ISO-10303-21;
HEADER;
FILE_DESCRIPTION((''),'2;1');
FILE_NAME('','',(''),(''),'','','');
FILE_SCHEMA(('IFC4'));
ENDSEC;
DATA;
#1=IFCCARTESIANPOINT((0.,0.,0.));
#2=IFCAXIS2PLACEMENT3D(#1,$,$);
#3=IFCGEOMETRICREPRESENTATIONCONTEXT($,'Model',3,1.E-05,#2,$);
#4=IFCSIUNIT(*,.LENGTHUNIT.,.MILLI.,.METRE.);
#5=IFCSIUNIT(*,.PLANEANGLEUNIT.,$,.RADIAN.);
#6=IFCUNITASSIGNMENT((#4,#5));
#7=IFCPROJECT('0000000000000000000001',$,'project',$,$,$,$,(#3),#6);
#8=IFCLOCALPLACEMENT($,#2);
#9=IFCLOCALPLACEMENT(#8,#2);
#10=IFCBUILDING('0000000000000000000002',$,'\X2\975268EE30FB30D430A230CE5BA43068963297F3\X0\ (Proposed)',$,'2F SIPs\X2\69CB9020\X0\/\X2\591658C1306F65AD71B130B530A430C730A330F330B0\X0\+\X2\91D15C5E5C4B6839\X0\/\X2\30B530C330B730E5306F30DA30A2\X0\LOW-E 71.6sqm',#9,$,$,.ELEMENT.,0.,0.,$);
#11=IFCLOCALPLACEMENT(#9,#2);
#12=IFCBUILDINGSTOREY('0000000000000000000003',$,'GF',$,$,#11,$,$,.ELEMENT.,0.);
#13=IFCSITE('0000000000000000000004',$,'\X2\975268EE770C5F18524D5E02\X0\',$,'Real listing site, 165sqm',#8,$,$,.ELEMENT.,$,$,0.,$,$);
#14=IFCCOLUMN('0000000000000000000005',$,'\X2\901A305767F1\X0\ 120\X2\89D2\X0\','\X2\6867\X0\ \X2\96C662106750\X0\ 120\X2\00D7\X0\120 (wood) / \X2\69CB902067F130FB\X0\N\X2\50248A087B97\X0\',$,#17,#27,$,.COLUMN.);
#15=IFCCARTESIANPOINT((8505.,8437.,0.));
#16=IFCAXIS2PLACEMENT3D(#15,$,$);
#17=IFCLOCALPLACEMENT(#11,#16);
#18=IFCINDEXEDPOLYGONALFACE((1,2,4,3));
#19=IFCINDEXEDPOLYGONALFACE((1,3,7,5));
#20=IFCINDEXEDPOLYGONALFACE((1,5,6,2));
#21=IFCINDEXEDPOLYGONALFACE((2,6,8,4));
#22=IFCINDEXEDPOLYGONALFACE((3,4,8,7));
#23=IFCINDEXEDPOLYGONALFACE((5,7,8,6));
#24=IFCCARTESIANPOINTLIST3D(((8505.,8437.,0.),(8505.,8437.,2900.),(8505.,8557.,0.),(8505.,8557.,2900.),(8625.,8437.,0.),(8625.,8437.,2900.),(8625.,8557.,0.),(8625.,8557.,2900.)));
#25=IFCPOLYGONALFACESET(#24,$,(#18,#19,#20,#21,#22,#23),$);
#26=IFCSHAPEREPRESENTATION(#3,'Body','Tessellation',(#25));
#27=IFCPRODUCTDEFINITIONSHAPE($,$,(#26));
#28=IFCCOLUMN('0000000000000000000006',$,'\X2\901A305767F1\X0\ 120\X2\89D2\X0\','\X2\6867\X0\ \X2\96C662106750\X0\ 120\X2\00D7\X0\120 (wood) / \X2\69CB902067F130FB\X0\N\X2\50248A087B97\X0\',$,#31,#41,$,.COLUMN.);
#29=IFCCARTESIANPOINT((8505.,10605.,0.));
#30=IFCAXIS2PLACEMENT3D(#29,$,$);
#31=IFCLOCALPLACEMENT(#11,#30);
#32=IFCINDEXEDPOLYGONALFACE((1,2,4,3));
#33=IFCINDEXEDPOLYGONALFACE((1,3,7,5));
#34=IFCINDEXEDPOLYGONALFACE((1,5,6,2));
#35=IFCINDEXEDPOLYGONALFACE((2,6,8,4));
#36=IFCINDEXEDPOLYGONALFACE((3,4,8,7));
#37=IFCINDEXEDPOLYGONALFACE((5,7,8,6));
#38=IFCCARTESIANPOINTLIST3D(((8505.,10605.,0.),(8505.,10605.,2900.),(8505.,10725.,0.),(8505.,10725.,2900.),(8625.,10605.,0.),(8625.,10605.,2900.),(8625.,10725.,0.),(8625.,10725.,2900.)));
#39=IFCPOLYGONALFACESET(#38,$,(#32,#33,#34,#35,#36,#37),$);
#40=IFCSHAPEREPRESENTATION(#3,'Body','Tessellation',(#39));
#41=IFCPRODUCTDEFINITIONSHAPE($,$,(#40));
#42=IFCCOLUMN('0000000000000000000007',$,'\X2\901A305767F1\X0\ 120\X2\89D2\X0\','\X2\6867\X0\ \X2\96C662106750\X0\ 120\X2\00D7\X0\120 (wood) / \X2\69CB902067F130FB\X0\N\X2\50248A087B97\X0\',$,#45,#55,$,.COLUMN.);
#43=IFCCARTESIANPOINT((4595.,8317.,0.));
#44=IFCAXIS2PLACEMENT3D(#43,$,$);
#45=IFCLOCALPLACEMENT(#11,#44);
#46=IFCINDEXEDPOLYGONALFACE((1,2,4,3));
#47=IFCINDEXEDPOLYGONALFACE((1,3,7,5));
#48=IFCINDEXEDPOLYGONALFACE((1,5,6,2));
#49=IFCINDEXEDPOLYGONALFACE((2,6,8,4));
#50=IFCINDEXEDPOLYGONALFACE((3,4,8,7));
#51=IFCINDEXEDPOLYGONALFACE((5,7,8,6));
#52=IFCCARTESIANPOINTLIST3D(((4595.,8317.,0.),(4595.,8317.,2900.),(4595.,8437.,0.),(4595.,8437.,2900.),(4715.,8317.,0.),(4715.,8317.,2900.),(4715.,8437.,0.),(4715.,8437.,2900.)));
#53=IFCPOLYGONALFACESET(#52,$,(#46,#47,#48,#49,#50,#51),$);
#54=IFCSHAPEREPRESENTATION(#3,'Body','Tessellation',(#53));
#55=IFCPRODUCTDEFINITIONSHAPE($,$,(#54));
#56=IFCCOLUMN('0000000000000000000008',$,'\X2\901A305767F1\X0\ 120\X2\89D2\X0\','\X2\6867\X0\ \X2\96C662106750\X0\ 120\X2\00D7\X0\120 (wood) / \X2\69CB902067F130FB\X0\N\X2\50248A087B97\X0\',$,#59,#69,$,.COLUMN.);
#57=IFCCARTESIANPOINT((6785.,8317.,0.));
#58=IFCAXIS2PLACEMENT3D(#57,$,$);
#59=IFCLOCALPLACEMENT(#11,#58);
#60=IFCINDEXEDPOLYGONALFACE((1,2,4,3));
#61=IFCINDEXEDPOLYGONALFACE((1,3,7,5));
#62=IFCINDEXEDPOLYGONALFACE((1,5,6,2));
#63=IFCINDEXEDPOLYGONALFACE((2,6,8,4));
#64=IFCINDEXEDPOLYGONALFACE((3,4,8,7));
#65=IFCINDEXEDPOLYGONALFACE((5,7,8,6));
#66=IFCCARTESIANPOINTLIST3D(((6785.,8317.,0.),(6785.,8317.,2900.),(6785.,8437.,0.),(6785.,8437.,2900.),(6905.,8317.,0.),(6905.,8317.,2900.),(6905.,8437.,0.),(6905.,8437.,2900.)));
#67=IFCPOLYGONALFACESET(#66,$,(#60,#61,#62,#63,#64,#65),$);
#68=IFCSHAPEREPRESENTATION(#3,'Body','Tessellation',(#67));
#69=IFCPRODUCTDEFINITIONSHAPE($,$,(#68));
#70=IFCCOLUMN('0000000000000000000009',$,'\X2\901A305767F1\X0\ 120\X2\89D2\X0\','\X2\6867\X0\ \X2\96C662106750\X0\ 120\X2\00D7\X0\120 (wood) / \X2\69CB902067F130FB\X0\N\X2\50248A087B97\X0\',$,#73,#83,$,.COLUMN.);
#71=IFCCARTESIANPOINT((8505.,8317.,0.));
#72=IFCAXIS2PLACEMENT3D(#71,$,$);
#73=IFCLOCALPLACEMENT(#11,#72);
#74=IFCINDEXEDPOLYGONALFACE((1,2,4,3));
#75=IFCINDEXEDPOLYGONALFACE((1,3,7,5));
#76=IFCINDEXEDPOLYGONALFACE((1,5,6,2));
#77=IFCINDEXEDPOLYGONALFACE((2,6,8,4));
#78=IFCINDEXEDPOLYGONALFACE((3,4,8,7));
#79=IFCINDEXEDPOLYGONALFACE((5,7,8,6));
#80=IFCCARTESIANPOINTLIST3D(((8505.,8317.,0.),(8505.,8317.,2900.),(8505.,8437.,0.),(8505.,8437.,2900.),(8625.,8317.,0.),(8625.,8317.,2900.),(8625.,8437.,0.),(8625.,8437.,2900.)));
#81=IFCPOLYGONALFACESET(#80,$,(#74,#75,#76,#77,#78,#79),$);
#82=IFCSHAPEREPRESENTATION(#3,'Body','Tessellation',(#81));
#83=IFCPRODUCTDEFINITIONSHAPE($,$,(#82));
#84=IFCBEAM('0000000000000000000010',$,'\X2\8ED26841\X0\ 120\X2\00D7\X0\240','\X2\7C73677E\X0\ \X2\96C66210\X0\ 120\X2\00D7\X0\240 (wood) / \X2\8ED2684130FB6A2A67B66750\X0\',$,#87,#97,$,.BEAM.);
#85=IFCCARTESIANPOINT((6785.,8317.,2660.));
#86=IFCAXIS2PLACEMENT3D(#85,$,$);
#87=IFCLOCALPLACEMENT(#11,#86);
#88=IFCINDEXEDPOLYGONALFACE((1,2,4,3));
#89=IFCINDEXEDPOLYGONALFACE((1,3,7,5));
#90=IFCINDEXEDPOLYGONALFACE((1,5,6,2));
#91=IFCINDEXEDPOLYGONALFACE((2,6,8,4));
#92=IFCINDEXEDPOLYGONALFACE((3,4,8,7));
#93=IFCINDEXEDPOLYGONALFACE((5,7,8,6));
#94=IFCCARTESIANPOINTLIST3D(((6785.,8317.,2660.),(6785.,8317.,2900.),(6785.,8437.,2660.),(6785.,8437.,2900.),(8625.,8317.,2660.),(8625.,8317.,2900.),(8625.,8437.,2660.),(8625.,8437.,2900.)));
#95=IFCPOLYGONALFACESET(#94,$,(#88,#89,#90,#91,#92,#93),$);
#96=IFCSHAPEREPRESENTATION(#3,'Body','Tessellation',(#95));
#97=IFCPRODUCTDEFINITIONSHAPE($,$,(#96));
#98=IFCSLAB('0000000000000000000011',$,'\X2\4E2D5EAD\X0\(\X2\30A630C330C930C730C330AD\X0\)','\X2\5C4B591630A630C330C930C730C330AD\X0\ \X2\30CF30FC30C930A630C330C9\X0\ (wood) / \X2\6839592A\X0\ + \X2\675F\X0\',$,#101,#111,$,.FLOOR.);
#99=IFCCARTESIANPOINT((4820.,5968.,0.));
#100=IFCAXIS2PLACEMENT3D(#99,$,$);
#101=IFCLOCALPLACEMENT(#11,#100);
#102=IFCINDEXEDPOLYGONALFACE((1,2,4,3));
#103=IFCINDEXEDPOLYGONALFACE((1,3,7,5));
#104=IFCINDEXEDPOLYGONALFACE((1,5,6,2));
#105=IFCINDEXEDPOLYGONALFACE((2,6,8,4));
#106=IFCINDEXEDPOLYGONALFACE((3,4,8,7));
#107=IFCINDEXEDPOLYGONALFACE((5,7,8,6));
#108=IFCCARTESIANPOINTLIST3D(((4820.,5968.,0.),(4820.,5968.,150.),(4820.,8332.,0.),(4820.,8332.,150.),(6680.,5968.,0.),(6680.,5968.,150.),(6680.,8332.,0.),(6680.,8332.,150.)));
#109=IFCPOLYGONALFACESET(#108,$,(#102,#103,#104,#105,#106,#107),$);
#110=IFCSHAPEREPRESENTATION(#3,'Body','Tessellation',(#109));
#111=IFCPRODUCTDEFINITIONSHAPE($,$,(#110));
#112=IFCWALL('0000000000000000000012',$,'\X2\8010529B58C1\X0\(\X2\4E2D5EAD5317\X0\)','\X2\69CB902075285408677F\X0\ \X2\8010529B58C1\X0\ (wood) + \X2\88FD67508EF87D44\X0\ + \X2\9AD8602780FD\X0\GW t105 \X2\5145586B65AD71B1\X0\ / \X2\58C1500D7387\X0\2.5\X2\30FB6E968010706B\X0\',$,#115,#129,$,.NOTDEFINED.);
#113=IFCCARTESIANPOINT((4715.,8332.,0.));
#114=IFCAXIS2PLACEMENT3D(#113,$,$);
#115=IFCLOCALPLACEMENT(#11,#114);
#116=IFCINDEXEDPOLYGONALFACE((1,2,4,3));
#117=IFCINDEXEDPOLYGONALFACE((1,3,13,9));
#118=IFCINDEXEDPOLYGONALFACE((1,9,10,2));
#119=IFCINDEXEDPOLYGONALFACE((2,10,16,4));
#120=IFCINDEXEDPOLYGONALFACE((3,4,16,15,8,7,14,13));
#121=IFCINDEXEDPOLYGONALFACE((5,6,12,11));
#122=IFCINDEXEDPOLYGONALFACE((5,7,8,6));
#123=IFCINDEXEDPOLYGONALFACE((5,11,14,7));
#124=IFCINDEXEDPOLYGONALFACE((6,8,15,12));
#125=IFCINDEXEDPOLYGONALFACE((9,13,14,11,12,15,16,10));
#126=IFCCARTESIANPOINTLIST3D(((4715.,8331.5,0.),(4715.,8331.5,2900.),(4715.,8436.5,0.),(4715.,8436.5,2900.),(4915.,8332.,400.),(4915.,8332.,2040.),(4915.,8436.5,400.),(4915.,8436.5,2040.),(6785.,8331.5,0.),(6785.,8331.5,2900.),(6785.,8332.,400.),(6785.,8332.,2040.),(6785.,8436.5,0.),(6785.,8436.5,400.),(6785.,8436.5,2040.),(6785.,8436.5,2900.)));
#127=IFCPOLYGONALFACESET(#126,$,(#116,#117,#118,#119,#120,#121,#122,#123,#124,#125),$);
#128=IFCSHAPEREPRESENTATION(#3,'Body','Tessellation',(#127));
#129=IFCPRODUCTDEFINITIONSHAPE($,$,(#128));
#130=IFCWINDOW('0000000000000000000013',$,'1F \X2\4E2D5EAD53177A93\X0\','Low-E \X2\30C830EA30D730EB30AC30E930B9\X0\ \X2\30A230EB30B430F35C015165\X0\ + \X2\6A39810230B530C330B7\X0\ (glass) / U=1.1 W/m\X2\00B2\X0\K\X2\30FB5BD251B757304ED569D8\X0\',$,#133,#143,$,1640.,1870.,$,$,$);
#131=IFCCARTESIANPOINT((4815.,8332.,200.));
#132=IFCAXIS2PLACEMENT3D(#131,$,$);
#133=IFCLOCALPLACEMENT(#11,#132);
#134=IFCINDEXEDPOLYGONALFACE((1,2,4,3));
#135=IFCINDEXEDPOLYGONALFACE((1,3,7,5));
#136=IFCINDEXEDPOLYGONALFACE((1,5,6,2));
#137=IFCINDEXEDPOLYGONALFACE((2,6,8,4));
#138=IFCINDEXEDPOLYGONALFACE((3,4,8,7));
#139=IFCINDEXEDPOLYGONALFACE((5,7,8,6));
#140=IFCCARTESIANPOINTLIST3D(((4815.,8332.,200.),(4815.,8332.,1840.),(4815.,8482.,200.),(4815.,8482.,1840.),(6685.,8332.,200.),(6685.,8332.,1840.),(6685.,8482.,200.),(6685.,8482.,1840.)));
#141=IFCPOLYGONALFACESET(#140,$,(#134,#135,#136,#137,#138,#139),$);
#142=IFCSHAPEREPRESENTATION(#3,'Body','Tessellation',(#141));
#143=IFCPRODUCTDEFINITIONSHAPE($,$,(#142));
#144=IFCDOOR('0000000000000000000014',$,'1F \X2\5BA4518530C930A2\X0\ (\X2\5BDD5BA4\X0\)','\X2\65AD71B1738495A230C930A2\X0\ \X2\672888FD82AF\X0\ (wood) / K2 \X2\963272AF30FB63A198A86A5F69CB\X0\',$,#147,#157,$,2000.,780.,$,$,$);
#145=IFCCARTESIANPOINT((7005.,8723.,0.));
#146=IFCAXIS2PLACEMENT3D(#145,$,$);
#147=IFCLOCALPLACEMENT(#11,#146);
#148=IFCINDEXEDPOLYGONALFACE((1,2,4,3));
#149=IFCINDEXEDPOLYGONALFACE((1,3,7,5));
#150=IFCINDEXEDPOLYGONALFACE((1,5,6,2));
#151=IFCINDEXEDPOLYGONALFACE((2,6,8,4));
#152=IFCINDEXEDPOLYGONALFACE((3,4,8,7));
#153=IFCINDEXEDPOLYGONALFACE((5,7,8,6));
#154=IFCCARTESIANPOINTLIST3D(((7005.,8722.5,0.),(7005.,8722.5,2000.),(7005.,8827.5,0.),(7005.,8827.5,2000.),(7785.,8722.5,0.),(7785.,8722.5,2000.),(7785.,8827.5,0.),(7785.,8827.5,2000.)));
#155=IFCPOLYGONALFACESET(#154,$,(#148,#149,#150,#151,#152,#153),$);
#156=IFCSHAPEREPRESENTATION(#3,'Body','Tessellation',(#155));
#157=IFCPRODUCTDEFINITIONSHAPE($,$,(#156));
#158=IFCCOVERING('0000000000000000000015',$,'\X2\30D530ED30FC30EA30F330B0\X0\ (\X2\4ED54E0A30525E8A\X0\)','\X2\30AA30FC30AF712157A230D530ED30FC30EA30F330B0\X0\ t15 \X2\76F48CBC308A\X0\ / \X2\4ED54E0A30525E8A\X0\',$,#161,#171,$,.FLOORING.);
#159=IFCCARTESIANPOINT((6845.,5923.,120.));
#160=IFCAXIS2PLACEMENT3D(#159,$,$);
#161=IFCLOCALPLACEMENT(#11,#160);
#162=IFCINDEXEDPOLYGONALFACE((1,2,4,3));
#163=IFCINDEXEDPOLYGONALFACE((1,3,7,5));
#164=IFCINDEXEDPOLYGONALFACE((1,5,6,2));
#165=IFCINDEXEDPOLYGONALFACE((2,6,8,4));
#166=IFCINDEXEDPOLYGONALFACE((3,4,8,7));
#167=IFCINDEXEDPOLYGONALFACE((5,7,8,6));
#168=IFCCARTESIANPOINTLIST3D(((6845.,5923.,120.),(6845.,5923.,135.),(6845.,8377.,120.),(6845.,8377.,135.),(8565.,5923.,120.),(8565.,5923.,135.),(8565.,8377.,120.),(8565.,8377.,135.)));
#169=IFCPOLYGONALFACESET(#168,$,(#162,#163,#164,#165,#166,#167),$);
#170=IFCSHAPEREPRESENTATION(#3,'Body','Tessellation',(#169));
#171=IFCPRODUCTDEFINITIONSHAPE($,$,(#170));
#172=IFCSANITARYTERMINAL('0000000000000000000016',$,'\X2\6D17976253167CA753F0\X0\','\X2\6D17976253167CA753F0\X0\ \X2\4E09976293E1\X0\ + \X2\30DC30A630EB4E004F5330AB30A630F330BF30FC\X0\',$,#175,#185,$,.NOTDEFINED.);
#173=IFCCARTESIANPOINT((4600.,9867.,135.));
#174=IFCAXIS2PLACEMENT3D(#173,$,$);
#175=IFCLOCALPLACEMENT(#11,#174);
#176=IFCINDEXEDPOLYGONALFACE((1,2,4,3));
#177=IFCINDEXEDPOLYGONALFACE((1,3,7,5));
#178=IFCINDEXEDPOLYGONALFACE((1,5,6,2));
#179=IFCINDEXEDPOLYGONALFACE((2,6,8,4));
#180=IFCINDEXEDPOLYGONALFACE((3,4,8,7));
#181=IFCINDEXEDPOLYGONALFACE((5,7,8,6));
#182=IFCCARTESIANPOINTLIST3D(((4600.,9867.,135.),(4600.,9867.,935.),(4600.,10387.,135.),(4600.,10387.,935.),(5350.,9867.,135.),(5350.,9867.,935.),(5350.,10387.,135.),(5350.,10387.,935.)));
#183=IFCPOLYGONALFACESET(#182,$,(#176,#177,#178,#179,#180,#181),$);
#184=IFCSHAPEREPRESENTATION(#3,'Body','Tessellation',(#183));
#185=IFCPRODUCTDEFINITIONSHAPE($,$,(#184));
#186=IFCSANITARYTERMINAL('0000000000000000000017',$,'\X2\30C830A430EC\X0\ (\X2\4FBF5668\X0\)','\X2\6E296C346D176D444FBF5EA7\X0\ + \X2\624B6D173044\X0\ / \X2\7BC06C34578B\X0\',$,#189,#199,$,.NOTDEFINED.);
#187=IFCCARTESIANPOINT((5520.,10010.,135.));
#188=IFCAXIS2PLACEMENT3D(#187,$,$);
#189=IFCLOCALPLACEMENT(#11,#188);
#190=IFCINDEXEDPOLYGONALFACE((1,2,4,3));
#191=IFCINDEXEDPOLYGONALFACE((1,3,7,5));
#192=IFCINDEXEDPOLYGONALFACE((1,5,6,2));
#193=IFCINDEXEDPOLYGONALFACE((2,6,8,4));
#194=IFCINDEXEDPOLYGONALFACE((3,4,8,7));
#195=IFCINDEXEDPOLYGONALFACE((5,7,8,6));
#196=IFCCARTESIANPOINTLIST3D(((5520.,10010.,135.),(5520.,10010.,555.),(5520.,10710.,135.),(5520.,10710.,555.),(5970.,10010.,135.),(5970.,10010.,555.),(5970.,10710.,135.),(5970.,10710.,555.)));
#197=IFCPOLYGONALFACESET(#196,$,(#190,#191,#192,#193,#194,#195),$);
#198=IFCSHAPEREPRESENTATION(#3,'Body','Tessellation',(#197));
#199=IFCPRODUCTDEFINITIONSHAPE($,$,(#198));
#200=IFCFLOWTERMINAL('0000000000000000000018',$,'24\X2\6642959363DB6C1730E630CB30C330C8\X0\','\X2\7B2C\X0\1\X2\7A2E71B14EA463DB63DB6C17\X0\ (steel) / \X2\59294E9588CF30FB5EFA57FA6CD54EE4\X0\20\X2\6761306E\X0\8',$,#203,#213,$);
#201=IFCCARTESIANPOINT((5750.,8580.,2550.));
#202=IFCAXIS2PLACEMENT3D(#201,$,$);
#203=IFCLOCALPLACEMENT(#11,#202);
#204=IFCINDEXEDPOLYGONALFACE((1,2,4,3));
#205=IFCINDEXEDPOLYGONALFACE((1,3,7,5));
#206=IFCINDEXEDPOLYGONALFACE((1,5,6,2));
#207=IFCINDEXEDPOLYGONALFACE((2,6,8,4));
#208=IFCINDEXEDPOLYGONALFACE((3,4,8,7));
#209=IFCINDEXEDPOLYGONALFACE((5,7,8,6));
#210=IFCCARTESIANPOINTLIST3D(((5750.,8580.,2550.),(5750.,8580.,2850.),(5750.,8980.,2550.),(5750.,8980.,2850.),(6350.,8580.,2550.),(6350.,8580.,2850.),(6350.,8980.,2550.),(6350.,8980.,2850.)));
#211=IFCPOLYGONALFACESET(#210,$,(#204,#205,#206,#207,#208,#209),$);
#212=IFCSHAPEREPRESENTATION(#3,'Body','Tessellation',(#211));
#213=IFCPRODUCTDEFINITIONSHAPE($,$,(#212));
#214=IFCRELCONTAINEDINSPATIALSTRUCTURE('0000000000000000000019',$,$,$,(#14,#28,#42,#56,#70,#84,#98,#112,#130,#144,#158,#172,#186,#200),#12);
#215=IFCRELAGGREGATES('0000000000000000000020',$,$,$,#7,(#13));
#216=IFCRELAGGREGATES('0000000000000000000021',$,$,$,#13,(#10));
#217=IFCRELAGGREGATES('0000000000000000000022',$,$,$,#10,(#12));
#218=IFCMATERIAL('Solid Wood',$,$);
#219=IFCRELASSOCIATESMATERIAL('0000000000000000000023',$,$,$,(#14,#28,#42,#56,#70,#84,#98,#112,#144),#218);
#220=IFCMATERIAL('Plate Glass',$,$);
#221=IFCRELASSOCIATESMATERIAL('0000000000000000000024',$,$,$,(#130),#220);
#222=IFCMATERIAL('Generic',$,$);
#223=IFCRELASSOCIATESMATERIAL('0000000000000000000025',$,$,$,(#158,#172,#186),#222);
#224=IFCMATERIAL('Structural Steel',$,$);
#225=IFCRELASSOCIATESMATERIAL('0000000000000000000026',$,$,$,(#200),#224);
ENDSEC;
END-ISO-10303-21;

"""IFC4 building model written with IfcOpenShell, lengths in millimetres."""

from ifc_helpers import new_model, si_unit, frame, frame_2d, origin, place, context, project, spatial, rectangle, extrude, material, element, fill, save


model = new_model("IFC4")

# Units and contexts
model_context = context("Model", 3, precision=1e-05, world=origin())
ifc_project = project(units=[si_unit("LENGTHUNIT", "METRE", prefix="MILLI"), si_unit("PLANEANGLEUNIT", "RADIAN")], contexts=[model_context])

# Site, building, storey
site_placement = place(None, origin())
site = spatial("IfcSite", under=ifc_project, at=site_placement, Name="青森県弘前市", ObjectType="Real listing site, 165sqm", CompositionType="ELEMENT", RefElevation=0.0)
building_placement = place(site_placement, origin())
building = spatial("IfcBuilding", under=site, at=building_placement, Name="青森・ピアノ室と防音 (Proposed)", ObjectType="2F SIPs構造/外壁は断熱サイディング+金属屋根/サッシュはペアLOW-E 71.6sqm", CompositionType="ELEMENT", ElevationOfRefHeight=0.0, ElevationOfTerrain=0.0)
storey_placement = place(building_placement, origin())
storey = spatial("IfcBuildingStorey", under=building, at=storey_placement, Name="GF", CompositionType="ELEMENT", Elevation=0.0)

# Columns
ifc_material_1 = material(Name="Solid Wood")
column_1_placement = place(storey_placement, frame((8505.0, 8437.0, 0.0)))
element("IfcColumn", 1, at=column_1_placement, inside=storey, material=ifc_material_1, Name="通し柱 120角", Description="桧 集成材 120×120 (wood) / 構造柱・N値計算", PredefinedType="COLUMN", context=model_context, shape_type="SweptSolid", body=[
    extrude(rectangle(XDim=120.0, YDim=120.0, at=frame_2d((60.0, 60.0))), frame((8505.0, 8437.0, 0.0)), (0.0, 0.0, 1.0), 2900.0),
])
column_2_placement = place(storey_placement, frame((8505.0, 10605.0, 0.0)))
element("IfcColumn", 2, at=column_2_placement, inside=storey, material=ifc_material_1, Name="通し柱 120角", Description="桧 集成材 120×120 (wood) / 構造柱・N値計算", PredefinedType="COLUMN", context=model_context, shape_type="SweptSolid", body=[
    extrude(rectangle(XDim=120.0, YDim=120.0, at=frame_2d((60.0, 60.0))), frame((8505.0, 10605.0, 0.0)), (0.0, 0.0, 1.0), 2900.0),
])
column_3_placement = place(storey_placement, frame((4595.0, 8317.0, 0.0)))
element("IfcColumn", 3, at=column_3_placement, inside=storey, material=ifc_material_1, Name="通し柱 120角", Description="桧 集成材 120×120 (wood) / 構造柱・N値計算", PredefinedType="COLUMN", context=model_context, shape_type="SweptSolid", body=[
    extrude(rectangle(XDim=120.0, YDim=120.0, at=frame_2d((60.0, 60.0))), frame((4595.0, 8317.0, 0.0)), (0.0, 0.0, 1.0), 2900.0),
])
column_4_placement = place(storey_placement, frame((6785.0, 8317.0, 0.0)))
element("IfcColumn", 4, at=column_4_placement, inside=storey, material=ifc_material_1, Name="通し柱 120角", Description="桧 集成材 120×120 (wood) / 構造柱・N値計算", PredefinedType="COLUMN", context=model_context, shape_type="SweptSolid", body=[
    extrude(rectangle(XDim=120.0, YDim=120.0, at=frame_2d((60.0, 60.0))), frame((6785.0, 8317.0, 0.0)), (0.0, 0.0, 1.0), 2900.0),
])
column_5_placement = place(storey_placement, frame((8505.0, 8317.0, 0.0)))
element("IfcColumn", 5, at=column_5_placement, inside=storey, material=ifc_material_1, Name="通し柱 120角", Description="桧 集成材 120×120 (wood) / 構造柱・N値計算", PredefinedType="COLUMN", context=model_context, shape_type="SweptSolid", body=[
    extrude(rectangle(XDim=120.0, YDim=120.0, at=frame_2d((60.0, 60.0))), frame((8505.0, 8317.0, 0.0)), (0.0, 0.0, 1.0), 2900.0),
])

# Beam
beam_1_placement = place(storey_placement, frame((6785.0, 8317.0, 2660.0)))
element("IfcBeam", 6, at=beam_1_placement, inside=storey, material=ifc_material_1, Name="軒桁 120×240", Description="米松 集成 120×240 (wood) / 軒桁・横架材", PredefinedType="BEAM", context=model_context, shape_type="SweptSolid", body=[
    extrude(rectangle(XDim=1840.0, YDim=120.0, at=frame_2d((920.0, 60.0))), frame((6785.0, 8317.0, 2660.0)), (0.0, 0.0, 1.0), 240.0),
])

# Slab
slab_placement = place(storey_placement, frame((4820.0, 5968.0, 0.0)))
element("IfcSlab", 7, at=slab_placement, inside=storey, material=ifc_material_1, Name="中庭(ウッドデッキ)", Description="屋外ウッドデッキ ハードウッド (wood) / 根太 + 束", PredefinedType="FLOOR", context=model_context, shape_type="SweptSolid", body=[
    extrude(rectangle(XDim=1860.0, YDim=2364.0, at=frame_2d((930.0, 1182.0))), frame((4820.0, 5968.0, 0.0)), (0.0, 0.0, 1.0), 150.0),
])

# Wall, opening, window
wall_1_placement = place(storey_placement, frame((4715.0, 8332.0, 0.0)))
wall_1 = element("IfcWall", 8, at=wall_1_placement, inside=storey, material=ifc_material_1, Name="耐力壁(中庭北)", Description="構造用合板 耐力壁 (wood) + 製材軸組 + 高性能GW t105 充填断熱 / 壁倍率2.5・準耐火", PredefinedType="NOTDEFINED", context=model_context, shape_type="SweptSolid", body=[
    extrude(rectangle(XDim=2070.0, YDim=105.0, at=frame_2d((1035.0, 52.0))), frame((4715.0, 8332.0, 0.0)), (0.0, 0.0, 1.0), 2900.0),
])
opening_placement = place(storey_placement, frame((4815.0, 8332.0, 200.0)))
opening = element("IfcOpeningElement", 9, at=opening_placement, cuts=wall_1, PredefinedType="NOTDEFINED", context=model_context, shape_type="SweptSolid", body=[
    extrude(rectangle(XDim=1870.0, YDim=150.0, at=frame_2d((935.0, 75.0))), frame((4815.0, 8332.0, 200.0)), (0.0, 0.0, 1.0), 1640.0),
])
ifc_material_2 = material(Name="Plate Glass")
window_placement = place(storey_placement, frame((4815.0, 8332.0, 200.0)))
window = element("IfcWindow", 10, at=window_placement, inside=storey, material=ifc_material_2, Name="1F 中庭北窓", Description="Low-E トリプルガラス アルゴン封入 + 樹脂サッシ (glass) / U=1.1 W/m²K・寒冷地仕様", OverallHeight=1640.0, OverallWidth=1870.0, context=model_context, shape_type="SweptSolid", body=[
    extrude(rectangle(XDim=1870.0, YDim=150.0, at=frame_2d((935.0, 75.0))), frame((4815.0, 8332.0, 200.0)), (0.0, 0.0, 1.0), 1640.0),
])
fill(opening, window)

# Door
door_placement = place(storey_placement, frame((7005.0, 8723.0, 0.0)))
element("IfcDoor", 11, at=door_placement, inside=storey, material=ifc_material_1, Name="1F 室内ドア (寝室)", Description="断熱玄関ドア 木製芯 (wood) / K2 防犯・採風機構", OverallHeight=2000.0, OverallWidth=780.0, context=model_context, shape_type="SweptSolid", body=[
    extrude(rectangle(XDim=780.0, YDim=105.0, at=frame_2d((390.0, 52.0))), frame((7005.0, 8723.0, 0.0)), (0.0, 0.0, 1.0), 2000.0),
])

# Covering
ifc_material_3 = material(Name="Generic")
covering_placement = place(storey_placement, frame((6845.0, 5923.0, 120.0)))
element("IfcCovering", 12, at=covering_placement, inside=storey, material=ifc_material_3, Name="フローリング (仕上げ床)", Description="オーク無垢フローリング t15 直貼り / 仕上げ床", PredefinedType="FLOORING", context=model_context, shape_type="SweptSolid", body=[
    extrude(rectangle(XDim=1720.0, YDim=2454.0, at=frame_2d((860.0, 1227.0))), frame((6845.0, 5923.0, 120.0)), (0.0, 0.0, 1.0), 15.0),
])

# Sanitary terminals
sanitary_terminal_1_placement = place(storey_placement, frame((4600.0, 9867.0, 135.0)))
element("IfcSanitaryTerminal", 13, at=sanitary_terminal_1_placement, inside=storey, material=ifc_material_3, Name="洗面化粧台", Description="洗面化粧台 三面鏡 + ボウル一体カウンター", PredefinedType="NOTDEFINED", context=model_context, shape_type="SweptSolid", body=[
    extrude(rectangle(XDim=750.0, YDim=520.0, at=frame_2d((375.0, 260.0))), frame((4600.0, 9867.0, 135.0)), (0.0, 0.0, 1.0), 800.0),
])
sanitary_terminal_2_placement = place(storey_placement, frame((5520.0, 10010.0, 135.0)))
element("IfcSanitaryTerminal", 14, at=sanitary_terminal_2_placement, inside=storey, material=ifc_material_3, Name="トイレ (便器)", Description="温水洗浄便座 + 手洗い / 節水型", PredefinedType="NOTDEFINED", context=model_context, shape_type="SweptSolid", body=[
    extrude(rectangle(XDim=450.0, YDim=700.0, at=frame_2d((225.0, 350.0))), frame((5520.0, 10010.0, 135.0)), (0.0, 0.0, 1.0), 420.0),
])

# Flow terminal
ifc_material_4 = material(Name="Structural Steel")
flow_terminal_placement = place(storey_placement, frame((5750.0, 8580.0, 2550.0)))
element("IfcFlowTerminal", 15, at=flow_terminal_placement, inside=storey, material=ifc_material_4, Name="24時間換気ユニット", Description="第1種熱交換換気 (steel) / 天井裏・建基法令20条の8", context=model_context, shape_type="SweptSolid", body=[
    extrude(rectangle(XDim=600.0, YDim=400.0, at=frame_2d((300.0, 200.0))), frame((5750.0, 8580.0, 2550.0)), (0.0, 0.0, 1.0), 300.0),
])

save(model, "model.ifc")
